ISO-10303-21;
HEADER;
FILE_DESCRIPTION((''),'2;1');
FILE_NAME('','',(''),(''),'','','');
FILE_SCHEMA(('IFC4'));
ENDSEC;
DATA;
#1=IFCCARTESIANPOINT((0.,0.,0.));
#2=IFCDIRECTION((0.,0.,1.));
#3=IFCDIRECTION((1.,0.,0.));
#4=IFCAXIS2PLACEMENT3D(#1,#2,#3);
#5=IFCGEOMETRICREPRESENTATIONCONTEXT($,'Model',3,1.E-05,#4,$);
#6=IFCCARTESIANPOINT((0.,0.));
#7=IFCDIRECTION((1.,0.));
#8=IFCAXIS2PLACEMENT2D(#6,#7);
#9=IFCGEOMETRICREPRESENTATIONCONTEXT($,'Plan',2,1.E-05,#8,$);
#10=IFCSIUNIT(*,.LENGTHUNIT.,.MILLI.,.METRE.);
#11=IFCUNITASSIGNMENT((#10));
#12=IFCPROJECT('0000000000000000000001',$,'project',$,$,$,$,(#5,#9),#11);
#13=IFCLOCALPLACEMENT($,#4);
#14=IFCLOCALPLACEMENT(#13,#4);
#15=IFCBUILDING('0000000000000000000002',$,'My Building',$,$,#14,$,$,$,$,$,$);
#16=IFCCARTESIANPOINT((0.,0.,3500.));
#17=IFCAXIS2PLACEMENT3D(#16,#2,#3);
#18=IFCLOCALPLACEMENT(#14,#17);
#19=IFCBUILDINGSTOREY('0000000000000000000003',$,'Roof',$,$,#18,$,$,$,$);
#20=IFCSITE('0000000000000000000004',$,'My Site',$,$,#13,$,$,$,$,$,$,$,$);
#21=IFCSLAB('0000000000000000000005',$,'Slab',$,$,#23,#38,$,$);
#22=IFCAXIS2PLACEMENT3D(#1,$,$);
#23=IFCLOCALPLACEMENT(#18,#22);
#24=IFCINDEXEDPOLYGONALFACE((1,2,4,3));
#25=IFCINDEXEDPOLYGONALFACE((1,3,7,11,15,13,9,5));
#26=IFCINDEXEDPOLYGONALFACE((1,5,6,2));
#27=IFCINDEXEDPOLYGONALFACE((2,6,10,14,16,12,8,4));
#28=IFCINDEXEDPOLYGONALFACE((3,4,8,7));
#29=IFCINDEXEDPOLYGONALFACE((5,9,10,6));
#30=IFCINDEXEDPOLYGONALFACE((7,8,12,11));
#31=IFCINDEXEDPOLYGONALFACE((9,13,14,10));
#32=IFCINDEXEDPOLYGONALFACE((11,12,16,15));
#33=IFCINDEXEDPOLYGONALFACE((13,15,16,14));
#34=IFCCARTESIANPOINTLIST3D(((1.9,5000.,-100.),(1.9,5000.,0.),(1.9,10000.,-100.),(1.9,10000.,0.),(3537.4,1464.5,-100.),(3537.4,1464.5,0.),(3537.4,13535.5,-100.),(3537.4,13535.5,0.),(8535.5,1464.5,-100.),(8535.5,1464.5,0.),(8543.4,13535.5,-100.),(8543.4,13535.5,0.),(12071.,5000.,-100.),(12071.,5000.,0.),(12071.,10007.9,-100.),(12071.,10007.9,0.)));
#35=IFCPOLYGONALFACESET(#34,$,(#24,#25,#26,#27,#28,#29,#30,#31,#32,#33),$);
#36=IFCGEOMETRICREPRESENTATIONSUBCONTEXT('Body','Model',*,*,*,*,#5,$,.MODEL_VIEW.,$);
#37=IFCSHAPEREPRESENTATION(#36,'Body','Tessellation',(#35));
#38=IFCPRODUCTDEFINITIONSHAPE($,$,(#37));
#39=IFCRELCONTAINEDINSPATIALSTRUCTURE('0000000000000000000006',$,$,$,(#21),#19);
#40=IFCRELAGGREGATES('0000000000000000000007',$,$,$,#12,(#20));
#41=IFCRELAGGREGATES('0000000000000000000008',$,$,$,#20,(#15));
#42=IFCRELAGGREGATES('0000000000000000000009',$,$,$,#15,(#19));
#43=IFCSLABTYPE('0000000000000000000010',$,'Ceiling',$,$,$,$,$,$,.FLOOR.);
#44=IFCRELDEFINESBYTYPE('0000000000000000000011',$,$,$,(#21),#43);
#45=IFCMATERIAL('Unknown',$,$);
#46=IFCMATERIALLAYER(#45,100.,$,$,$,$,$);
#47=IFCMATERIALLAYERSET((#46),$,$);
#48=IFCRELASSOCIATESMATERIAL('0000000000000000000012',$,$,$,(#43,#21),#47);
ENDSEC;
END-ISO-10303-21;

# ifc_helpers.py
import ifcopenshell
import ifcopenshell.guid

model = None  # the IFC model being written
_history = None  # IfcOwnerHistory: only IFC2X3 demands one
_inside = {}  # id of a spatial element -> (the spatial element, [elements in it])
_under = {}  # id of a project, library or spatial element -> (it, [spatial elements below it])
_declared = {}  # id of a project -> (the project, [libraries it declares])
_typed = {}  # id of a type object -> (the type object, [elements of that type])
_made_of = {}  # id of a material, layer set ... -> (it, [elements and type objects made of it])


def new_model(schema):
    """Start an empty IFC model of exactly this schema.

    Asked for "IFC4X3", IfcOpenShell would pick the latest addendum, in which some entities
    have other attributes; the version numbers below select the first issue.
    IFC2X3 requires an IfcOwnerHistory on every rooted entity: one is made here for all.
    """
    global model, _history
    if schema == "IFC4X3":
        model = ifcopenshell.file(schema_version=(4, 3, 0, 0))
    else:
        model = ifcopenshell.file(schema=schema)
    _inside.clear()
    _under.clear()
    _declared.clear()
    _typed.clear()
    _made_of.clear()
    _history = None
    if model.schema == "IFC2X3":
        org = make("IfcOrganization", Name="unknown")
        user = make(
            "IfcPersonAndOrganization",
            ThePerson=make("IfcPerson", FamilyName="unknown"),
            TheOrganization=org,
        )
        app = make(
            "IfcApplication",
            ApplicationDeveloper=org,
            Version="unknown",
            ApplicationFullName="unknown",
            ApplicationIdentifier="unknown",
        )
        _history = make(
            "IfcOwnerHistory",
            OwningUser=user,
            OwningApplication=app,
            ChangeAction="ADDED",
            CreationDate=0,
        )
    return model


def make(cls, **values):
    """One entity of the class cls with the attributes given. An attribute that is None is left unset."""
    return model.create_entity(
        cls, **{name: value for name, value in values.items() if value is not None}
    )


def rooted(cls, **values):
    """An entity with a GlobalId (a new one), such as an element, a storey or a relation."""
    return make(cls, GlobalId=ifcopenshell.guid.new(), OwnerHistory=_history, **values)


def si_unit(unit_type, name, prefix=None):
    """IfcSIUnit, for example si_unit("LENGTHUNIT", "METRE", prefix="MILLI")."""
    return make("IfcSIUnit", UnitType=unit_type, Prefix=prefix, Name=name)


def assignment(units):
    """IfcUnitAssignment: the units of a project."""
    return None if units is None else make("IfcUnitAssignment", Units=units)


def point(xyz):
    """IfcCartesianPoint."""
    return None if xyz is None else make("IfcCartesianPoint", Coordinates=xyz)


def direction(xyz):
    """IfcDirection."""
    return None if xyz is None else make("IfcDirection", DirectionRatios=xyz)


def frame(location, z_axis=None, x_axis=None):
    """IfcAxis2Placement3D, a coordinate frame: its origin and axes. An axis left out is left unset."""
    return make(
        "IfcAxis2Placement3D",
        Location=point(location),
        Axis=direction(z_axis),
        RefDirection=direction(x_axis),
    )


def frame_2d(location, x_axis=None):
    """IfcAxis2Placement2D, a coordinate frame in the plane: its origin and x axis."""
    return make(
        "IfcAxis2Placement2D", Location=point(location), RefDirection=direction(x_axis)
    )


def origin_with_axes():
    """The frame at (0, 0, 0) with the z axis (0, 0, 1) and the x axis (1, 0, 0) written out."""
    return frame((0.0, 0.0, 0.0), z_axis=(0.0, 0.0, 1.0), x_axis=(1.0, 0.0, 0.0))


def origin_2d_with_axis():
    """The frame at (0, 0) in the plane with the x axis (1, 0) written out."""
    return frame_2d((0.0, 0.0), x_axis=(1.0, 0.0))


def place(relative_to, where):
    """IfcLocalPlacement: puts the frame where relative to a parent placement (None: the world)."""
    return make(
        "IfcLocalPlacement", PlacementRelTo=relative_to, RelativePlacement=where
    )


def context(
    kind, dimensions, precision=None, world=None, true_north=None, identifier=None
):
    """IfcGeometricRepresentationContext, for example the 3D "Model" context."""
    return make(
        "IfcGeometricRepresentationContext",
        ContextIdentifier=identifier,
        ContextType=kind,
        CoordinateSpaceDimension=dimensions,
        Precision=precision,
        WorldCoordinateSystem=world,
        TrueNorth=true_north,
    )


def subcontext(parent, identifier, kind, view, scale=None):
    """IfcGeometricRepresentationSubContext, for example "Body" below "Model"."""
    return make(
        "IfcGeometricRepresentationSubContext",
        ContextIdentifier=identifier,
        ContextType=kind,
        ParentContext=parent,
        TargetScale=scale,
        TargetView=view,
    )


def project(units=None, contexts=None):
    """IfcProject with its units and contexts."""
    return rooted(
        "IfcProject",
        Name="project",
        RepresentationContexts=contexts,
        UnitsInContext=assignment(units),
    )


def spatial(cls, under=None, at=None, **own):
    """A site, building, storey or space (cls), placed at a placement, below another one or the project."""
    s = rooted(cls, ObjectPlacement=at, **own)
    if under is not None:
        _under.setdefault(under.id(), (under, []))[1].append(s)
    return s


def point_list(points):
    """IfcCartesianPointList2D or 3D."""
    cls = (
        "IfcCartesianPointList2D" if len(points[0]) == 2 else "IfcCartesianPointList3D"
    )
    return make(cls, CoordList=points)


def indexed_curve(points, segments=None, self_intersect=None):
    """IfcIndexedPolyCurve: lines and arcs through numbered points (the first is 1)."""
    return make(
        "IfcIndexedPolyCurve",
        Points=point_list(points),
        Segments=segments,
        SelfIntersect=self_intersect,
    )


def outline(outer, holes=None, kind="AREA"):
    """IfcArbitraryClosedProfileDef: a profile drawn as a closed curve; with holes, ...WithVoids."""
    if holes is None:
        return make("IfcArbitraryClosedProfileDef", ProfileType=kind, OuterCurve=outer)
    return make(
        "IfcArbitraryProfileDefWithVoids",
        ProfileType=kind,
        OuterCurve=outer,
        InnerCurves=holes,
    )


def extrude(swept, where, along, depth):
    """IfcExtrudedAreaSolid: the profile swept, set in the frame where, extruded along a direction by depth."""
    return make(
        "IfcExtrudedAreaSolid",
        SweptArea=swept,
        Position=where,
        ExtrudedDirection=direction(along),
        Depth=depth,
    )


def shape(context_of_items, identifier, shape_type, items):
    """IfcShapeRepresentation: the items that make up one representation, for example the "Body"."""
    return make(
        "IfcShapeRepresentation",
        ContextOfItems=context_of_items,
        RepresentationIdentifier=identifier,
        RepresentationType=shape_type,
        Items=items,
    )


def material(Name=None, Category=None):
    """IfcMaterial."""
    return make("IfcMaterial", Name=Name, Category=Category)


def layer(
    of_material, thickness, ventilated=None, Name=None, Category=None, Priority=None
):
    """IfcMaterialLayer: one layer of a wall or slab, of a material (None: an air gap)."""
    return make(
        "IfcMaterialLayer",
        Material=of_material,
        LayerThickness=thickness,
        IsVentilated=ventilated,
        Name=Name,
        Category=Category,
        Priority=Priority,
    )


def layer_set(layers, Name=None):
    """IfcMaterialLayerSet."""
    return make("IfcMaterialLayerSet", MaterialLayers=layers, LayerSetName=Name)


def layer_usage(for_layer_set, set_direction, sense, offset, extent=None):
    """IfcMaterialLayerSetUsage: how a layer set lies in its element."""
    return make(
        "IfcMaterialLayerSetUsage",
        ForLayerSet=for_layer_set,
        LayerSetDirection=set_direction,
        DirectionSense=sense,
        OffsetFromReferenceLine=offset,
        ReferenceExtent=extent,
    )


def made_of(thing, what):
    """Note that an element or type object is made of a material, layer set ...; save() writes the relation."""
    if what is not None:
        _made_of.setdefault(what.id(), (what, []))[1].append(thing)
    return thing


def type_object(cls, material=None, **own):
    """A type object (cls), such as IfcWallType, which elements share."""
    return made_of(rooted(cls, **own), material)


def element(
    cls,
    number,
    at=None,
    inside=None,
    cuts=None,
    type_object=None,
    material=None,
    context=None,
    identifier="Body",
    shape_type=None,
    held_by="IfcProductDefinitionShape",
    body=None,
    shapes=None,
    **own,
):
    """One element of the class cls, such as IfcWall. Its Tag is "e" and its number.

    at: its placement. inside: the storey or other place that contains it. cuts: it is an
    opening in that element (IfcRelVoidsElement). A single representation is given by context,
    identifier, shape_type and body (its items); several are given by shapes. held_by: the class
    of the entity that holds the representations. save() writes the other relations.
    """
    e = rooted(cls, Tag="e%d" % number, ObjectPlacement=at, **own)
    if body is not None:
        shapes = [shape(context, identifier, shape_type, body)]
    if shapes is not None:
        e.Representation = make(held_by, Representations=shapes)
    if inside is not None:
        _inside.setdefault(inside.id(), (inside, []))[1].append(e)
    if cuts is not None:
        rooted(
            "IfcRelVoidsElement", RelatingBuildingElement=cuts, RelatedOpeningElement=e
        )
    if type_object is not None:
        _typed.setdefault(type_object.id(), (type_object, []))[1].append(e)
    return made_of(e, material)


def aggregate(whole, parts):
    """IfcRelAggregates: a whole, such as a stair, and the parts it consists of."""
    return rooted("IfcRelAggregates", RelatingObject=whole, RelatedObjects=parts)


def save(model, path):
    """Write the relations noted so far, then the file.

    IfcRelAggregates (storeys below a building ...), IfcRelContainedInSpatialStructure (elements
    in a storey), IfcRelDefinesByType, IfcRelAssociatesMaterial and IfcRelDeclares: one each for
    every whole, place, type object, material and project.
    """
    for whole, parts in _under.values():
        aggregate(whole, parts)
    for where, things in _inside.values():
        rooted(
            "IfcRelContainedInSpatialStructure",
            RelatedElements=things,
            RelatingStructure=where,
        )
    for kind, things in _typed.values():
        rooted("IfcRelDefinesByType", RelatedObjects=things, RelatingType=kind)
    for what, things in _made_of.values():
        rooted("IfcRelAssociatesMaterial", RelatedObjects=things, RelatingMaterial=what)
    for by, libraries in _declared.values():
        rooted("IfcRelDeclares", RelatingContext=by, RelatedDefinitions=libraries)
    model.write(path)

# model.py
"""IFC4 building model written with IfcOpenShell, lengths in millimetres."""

from ifc_helpers import new_model, si_unit, frame, origin_with_axes, origin_2d_with_axis, place, context, subcontext, project, spatial, indexed_curve, outline, extrude, material, layer, layer_set, layer_usage, type_object, element, save


model = new_model("IFC4")

# Units and contexts
model_context = context("Model", 3, precision=1e-05, world=origin_with_axes())
plan_context = context("Plan", 2, precision=1e-05, world=origin_2d_with_axis())
body_context = subcontext(model_context, "Body", "Model", "MODEL_VIEW")
ifc_project = project(units=[si_unit("LENGTHUNIT", "METRE", prefix="MILLI")], contexts=[model_context, plan_context])

# Site, building, storey
site_placement = place(None, origin_with_axes())
site = spatial("IfcSite", under=ifc_project, at=site_placement, Name="My Site")
building_placement = place(site_placement, origin_with_axes())
building = spatial("IfcBuilding", under=site, at=building_placement, Name="My Building")
storey_placement = place(building_placement, frame((0.0, 0.0, 3500.0), z_axis=(0.0, 0.0, 1.0), x_axis=(1.0, 0.0, 0.0)))
storey = spatial("IfcBuildingStorey", under=building, at=storey_placement, Name="Roof")

# Slab
ifc_material = material(Name="Unknown")
ifc_layer = layer(ifc_material, 100.0)
ifc_layer_set = layer_set([ifc_layer])
ifc_layer_usage = layer_usage(ifc_layer_set, "AXIS3", "POSITIVE", -100.0)
slab_type = type_object("IfcSlabType", Name="Ceiling", PredefinedType="FLOOR", material=ifc_layer_set)
slab_placement = place(storey_placement, frame((8535.5, 1464.5, 0.0), z_axis=(0.0, 0.0, 1.0), x_axis=(1.0, 0.0, 0.0)))
element("IfcSlab", 1, at=slab_placement, inside=storey, type_object=slab_type, material=ifc_layer_usage, Name="Slab", context=body_context, shape_type="SweptSolid", body=[
    extrude(outline(indexed_curve([(0.0, 0.0), (-4998.1, 0.0), (-8533.7, 3535.5), (-8533.7, 8535.5), (-4998.1, 12071.1), (7.8, 12071.1), (3535.5, 8543.4), (3535.5, 3535.5), (0.0, 0.0)])), frame((0.0, 0.0, -100.0), z_axis=(0.0, 0.0, 1.0), x_axis=(1.0, 0.0, 0.0)), (0.0, 0.0, 1.0), 100.0),
])

save(model, "model.ifc")
